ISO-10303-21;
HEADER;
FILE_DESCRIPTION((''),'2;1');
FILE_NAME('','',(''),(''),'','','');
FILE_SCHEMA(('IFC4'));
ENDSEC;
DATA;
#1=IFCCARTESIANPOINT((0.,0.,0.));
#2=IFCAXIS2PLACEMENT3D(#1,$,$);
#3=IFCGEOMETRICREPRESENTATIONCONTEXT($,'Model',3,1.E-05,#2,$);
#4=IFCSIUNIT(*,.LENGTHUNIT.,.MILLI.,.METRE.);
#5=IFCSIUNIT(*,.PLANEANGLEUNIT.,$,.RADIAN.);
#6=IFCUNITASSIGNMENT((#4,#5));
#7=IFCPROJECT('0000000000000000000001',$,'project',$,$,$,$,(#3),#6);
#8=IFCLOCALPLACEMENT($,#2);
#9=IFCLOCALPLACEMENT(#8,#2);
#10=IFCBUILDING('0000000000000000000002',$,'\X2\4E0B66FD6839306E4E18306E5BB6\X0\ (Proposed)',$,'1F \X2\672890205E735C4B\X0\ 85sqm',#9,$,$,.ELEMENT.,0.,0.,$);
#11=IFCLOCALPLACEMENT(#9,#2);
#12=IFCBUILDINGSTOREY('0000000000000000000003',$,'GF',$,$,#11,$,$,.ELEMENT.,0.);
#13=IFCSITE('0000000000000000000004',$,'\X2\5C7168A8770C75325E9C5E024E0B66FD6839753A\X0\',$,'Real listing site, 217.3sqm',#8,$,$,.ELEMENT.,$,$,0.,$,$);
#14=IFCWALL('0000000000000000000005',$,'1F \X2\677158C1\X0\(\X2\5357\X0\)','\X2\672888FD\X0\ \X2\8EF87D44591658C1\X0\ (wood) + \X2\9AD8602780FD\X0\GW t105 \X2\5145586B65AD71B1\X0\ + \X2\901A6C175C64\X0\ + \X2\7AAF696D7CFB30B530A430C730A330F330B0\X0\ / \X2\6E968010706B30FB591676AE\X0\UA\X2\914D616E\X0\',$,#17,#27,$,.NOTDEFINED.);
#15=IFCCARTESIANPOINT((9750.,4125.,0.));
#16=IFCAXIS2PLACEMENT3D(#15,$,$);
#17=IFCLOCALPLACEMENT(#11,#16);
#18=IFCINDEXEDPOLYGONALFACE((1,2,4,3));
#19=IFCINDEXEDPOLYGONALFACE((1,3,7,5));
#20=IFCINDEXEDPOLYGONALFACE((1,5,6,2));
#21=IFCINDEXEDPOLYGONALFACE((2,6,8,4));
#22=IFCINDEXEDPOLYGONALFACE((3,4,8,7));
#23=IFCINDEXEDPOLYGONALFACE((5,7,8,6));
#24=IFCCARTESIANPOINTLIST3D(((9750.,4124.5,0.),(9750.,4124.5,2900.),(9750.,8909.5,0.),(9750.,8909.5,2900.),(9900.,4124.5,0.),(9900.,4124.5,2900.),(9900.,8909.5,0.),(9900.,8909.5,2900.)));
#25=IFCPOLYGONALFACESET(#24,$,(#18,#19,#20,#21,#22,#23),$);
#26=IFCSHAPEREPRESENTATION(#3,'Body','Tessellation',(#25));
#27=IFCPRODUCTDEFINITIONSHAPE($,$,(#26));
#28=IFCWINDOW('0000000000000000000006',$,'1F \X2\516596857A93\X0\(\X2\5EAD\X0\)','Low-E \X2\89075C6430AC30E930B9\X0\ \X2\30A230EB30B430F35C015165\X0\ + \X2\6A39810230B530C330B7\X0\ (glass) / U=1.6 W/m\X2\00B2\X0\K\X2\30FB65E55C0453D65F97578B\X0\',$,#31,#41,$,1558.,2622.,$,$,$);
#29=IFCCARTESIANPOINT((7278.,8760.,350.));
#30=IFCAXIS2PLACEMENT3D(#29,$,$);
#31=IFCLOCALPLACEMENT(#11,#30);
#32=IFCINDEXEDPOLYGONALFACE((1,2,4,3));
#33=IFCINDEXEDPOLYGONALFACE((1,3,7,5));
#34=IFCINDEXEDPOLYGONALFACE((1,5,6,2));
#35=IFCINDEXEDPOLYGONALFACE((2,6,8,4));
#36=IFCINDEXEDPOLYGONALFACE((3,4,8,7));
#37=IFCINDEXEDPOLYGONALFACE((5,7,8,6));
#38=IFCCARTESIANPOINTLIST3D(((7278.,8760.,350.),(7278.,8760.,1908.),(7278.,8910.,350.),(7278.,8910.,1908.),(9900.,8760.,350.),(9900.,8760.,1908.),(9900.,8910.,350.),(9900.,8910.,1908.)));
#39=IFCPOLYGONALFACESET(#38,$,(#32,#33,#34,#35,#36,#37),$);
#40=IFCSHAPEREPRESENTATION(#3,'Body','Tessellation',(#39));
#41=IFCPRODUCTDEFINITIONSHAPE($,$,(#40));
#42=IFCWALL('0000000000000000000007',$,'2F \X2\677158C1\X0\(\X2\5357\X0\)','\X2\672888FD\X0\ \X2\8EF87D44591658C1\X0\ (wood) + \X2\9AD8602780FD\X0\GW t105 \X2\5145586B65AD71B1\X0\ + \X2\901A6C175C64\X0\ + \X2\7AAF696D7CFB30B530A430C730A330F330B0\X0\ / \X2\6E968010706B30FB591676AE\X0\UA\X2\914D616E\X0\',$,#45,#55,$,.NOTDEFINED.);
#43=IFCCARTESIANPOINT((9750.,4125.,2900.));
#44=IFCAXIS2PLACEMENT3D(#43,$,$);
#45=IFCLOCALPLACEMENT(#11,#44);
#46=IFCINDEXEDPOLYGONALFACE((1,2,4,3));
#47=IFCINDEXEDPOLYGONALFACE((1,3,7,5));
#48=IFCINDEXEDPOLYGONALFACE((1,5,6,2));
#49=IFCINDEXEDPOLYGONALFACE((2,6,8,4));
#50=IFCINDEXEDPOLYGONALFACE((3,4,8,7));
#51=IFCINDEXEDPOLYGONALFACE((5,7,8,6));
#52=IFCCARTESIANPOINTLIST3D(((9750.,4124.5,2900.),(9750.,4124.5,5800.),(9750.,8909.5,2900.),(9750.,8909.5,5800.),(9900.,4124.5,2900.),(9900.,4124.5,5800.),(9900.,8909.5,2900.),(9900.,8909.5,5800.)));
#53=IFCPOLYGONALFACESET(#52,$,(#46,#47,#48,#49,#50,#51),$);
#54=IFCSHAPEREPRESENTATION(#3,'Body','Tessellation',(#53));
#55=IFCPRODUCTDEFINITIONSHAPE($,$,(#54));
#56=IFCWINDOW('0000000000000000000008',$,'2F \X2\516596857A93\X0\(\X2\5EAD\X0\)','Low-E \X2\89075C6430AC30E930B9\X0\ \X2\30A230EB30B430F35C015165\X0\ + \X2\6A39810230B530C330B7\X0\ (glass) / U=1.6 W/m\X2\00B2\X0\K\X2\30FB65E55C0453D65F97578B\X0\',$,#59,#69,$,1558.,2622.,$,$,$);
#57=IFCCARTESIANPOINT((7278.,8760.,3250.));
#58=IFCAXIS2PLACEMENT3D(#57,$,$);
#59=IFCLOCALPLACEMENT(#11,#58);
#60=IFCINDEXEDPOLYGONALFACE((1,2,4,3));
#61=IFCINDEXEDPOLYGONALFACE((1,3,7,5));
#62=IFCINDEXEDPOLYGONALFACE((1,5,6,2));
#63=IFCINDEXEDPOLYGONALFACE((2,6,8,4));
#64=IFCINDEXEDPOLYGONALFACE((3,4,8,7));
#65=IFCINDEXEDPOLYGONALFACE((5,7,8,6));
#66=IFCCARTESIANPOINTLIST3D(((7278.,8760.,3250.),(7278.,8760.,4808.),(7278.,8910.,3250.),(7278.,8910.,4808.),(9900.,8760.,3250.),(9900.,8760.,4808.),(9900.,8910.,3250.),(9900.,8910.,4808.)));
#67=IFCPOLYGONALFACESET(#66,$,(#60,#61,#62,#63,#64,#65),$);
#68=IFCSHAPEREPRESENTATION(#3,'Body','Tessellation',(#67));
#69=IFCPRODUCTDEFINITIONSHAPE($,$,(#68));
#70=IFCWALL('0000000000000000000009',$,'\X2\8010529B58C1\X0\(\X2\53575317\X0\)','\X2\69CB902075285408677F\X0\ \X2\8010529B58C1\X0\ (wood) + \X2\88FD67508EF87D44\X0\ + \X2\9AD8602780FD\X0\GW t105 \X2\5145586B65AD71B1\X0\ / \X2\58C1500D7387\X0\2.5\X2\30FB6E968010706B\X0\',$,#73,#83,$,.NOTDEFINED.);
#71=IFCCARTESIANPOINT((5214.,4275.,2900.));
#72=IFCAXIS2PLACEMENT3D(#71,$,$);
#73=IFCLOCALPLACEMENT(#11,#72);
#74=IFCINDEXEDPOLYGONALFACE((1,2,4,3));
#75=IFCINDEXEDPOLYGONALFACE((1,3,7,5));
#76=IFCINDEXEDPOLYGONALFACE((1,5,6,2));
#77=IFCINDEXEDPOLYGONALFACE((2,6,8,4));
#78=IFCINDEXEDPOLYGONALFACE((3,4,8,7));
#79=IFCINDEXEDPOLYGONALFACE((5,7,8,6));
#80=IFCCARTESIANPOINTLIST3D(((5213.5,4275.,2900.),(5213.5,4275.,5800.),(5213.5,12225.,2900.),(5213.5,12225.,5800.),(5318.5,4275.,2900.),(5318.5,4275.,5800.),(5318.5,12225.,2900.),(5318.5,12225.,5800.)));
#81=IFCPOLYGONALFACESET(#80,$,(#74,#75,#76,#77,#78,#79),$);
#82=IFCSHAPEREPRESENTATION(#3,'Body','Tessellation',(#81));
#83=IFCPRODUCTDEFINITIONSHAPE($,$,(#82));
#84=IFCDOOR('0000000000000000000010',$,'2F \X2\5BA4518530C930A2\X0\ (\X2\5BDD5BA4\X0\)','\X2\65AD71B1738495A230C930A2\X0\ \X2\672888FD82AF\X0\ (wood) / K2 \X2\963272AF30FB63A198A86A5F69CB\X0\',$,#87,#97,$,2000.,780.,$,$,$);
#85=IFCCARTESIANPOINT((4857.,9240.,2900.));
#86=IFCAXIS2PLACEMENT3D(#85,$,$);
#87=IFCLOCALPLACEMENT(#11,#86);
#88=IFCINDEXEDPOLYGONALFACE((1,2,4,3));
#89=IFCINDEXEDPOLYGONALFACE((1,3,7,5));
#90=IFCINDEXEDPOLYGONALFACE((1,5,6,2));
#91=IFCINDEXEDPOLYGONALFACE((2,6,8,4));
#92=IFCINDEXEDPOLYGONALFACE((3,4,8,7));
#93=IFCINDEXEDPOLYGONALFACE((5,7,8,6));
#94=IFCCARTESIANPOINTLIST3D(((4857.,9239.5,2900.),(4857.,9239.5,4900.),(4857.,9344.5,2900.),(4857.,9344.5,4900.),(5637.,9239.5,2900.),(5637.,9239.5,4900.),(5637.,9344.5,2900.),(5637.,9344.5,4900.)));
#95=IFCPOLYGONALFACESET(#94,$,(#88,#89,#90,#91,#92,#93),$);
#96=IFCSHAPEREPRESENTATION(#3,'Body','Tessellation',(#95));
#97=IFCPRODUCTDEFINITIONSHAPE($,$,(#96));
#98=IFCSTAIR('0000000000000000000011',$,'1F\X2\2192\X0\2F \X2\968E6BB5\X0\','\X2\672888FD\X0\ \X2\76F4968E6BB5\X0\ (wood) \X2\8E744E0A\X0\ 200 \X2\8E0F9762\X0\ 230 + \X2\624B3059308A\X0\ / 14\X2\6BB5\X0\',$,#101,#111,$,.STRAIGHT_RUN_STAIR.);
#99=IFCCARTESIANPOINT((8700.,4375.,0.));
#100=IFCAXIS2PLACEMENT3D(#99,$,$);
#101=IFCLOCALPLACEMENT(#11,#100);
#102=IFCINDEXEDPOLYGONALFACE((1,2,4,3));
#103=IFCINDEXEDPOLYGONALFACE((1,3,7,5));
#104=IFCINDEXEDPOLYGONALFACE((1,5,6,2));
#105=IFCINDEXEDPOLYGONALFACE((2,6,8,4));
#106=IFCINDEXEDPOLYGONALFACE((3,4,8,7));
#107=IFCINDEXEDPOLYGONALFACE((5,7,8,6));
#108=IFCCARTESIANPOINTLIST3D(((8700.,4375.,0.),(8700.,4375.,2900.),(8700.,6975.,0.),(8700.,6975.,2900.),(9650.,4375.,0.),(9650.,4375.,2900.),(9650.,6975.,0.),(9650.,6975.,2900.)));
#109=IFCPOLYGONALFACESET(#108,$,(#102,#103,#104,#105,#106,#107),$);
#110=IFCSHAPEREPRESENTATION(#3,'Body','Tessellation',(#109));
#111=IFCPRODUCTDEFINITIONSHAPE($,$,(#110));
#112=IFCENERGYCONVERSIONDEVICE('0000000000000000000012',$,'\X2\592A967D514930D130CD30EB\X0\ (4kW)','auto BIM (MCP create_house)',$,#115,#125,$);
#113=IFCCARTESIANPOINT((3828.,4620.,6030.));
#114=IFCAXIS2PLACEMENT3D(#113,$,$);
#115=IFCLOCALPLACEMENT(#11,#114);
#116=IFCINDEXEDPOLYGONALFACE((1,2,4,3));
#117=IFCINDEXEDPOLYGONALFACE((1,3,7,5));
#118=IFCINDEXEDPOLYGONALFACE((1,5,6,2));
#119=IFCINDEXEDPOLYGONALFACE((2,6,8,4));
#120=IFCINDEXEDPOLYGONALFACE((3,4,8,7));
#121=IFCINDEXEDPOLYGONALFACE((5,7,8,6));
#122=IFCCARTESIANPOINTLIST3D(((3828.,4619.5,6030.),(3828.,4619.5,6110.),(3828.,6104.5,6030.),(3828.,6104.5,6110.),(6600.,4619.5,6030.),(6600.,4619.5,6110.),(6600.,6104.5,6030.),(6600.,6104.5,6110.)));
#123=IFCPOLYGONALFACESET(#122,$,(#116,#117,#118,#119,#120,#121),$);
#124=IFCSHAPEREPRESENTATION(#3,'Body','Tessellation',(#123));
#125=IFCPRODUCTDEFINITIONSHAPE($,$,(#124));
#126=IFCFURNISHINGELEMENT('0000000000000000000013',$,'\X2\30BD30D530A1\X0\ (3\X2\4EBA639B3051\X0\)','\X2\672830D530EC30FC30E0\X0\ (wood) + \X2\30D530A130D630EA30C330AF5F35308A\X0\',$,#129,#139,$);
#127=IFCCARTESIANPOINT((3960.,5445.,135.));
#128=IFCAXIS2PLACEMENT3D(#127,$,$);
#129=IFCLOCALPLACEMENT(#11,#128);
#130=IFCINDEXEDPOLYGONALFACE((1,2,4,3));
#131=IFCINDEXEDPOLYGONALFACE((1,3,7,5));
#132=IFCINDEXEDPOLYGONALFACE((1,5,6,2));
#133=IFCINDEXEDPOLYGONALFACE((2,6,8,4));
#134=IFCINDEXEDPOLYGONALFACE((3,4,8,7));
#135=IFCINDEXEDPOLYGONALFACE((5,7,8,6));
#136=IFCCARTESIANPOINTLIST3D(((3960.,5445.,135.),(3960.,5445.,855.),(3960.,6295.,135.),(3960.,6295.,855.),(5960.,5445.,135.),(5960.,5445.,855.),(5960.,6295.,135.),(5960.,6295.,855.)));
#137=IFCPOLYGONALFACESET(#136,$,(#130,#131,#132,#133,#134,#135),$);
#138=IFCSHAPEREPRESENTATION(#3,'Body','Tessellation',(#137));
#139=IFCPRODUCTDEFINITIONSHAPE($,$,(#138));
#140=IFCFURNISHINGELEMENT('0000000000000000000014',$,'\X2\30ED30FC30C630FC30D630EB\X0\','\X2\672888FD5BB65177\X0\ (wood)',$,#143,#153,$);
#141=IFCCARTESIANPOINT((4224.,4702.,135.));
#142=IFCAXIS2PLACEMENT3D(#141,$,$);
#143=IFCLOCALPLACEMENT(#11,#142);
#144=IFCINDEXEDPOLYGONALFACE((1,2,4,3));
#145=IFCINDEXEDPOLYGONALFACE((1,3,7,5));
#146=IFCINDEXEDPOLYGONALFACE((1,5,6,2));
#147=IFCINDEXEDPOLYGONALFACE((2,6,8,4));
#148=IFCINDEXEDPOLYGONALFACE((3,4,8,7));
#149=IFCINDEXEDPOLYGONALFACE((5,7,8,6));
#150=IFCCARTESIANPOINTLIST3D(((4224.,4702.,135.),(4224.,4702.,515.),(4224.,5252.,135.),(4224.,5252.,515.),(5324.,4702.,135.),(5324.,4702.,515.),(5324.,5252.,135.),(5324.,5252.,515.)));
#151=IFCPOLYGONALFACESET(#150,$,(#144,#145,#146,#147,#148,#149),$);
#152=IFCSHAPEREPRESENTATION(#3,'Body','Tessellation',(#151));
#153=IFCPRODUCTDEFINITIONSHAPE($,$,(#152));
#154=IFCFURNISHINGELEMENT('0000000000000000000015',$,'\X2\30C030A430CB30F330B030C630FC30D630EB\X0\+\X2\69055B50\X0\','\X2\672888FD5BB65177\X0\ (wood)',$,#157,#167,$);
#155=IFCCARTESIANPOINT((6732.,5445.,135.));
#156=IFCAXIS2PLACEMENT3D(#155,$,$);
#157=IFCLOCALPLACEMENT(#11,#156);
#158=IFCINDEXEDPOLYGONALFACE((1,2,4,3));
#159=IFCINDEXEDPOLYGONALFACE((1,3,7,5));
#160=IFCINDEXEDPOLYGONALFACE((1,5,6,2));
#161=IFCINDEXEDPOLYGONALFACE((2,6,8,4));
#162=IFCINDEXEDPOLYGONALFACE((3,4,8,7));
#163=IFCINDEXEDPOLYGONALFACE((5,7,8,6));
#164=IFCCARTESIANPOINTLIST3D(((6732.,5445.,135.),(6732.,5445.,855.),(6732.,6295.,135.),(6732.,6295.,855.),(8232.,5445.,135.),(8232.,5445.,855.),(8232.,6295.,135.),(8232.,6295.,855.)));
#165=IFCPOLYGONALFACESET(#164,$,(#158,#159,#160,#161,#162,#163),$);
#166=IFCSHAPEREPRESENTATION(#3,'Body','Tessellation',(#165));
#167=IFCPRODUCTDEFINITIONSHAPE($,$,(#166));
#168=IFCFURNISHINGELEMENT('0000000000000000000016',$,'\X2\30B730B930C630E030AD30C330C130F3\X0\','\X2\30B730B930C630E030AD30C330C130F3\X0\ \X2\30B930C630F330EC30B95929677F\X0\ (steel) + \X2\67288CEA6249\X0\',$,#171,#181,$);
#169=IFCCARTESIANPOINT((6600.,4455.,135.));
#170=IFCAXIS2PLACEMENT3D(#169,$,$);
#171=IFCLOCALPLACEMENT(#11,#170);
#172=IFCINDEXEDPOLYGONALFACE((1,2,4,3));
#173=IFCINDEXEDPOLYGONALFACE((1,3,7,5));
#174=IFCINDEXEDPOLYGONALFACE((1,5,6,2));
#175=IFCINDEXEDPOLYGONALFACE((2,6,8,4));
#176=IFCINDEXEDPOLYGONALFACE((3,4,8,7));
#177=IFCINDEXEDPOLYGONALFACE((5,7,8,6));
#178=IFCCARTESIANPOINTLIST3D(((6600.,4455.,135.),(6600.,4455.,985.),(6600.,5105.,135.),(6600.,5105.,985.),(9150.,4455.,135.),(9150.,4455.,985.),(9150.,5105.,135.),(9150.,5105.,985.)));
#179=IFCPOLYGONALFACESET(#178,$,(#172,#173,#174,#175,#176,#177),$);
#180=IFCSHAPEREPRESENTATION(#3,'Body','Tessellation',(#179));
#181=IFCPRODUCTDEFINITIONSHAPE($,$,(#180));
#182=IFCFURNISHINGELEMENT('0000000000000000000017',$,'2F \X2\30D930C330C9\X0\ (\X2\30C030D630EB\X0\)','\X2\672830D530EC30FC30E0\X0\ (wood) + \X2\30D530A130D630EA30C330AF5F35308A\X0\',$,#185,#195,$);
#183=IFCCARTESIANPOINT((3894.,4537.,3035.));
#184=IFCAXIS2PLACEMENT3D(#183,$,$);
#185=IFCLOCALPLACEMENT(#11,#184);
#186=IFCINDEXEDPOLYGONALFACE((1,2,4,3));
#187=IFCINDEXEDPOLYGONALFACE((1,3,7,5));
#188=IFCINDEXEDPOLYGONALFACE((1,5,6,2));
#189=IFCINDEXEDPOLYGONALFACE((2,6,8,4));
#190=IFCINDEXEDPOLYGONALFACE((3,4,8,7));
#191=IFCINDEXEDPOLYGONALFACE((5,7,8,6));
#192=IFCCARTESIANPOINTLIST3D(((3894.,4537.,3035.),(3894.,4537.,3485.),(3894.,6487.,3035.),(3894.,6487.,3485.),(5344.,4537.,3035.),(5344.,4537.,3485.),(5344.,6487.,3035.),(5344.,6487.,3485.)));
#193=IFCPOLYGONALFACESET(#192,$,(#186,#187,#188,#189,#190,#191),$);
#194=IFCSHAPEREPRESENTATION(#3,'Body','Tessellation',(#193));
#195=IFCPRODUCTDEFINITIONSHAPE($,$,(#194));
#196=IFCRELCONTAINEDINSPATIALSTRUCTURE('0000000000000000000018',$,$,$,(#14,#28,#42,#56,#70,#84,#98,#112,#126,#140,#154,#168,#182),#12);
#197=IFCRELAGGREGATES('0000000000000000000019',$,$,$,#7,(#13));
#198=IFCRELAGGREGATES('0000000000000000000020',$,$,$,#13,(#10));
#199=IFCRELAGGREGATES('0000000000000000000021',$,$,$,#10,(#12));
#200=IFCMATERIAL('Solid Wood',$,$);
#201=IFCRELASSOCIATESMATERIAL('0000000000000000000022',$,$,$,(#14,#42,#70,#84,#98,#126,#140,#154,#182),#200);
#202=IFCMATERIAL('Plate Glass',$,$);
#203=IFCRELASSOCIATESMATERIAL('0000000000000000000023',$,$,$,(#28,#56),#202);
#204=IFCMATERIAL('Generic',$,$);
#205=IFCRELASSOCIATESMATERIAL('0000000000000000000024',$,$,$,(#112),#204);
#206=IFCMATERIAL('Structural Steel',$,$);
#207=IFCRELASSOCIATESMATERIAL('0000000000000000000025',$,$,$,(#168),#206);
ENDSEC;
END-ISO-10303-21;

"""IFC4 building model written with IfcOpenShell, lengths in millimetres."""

from ifc_helpers import new_model, si_unit, frame, frame_2d, origin, place, context, project, spatial, rectangle, extrude, material, element, fill, save


model = new_model("IFC4")

# Units and contexts
model_context = context("Model", 3, precision=1e-05, world=origin())
ifc_project = project(units=[si_unit("LENGTHUNIT", "METRE", prefix="MILLI"), si_unit("PLANEANGLEUNIT", "RADIAN")], contexts=[model_context])

# Site, building, storey
site_placement = place(None, origin())
site = spatial("IfcSite", under=ifc_project, at=site_placement, Name="山梨県甲府市下曽根町", ObjectType="Real listing site, 217.3sqm", CompositionType="ELEMENT", RefElevation=0.0)
building_placement = place(site_placement, origin())
building = spatial("IfcBuilding", under=site, at=building_placement, Name="下曽根の丘の家 (Proposed)", ObjectType="1F 木造平屋 85sqm", CompositionType="ELEMENT", ElevationOfRefHeight=0.0, ElevationOfTerrain=0.0)
storey_placement = place(building_placement, origin())
storey = spatial("IfcBuildingStorey", under=building, at=storey_placement, Name="GF", CompositionType="ELEMENT", Elevation=0.0)

# Wall, opening, window
ifc_material_1 = material(Name="Solid Wood")
wall_1_placement = place(storey_placement, frame((9750.0, 4125.0, 0.0)))
wall_1 = element("IfcWall", 1, at=wall_1_placement, inside=storey, material=ifc_material_1, Name="1F 東壁(南)", Description="木製 軸組外壁 (wood) + 高性能GW t105 充填断熱 + 通気層 + 窯業系サイディング / 準耐火・外皮UA配慮", PredefinedType="NOTDEFINED", context=model_context, shape_type="SweptSolid", body=[
    extrude(rectangle(XDim=150.0, YDim=4785.0, at=frame_2d((75.0, 2392.0))), frame((9750.0, 4125.0, 0.0)), (0.0, 0.0, 1.0), 2900.0),
])
opening_1_placement = place(storey_placement, frame((7278.0, 8760.0, 350.0)))
opening_1 = element("IfcOpeningElement", 2, at=opening_1_placement, cuts=wall_1, PredefinedType="NOTDEFINED", context=model_context, shape_type="SweptSolid", body=[
    extrude(rectangle(XDim=2622.0, YDim=150.0, at=frame_2d((1311.0, 75.0))), frame((7278.0, 8760.0, 350.0)), (0.0, 0.0, 1.0), 1558.0),
])
ifc_material_2 = material(Name="Plate Glass")
window_1_placement = place(storey_placement, frame((7278.0, 8760.0, 350.0)))
window_1 = element("IfcWindow", 3, at=window_1_placement, inside=storey, material=ifc_material_2, Name="1F 入隅窓(庭)", Description="Low-E 複層ガラス アルゴン封入 + 樹脂サッシ (glass) / U=1.6 W/m²K・日射取得型", OverallHeight=1558.0, OverallWidth=2622.0, context=model_context, shape_type="SweptSolid", body=[
    extrude(rectangle(XDim=2622.0, YDim=150.0, at=frame_2d((1311.0, 75.0))), frame((7278.0, 8760.0, 350.0)), (0.0, 0.0, 1.0), 1558.0),
])
fill(opening_1, window_1)

# Wall, opening, window
wall_2_placement = place(storey_placement, frame((9750.0, 4125.0, 2900.0)))
wall_2 = element("IfcWall", 4, at=wall_2_placement, inside=storey, material=ifc_material_1, Name="2F 東壁(南)", Description="木製 軸組外壁 (wood) + 高性能GW t105 充填断熱 + 通気層 + 窯業系サイディング / 準耐火・外皮UA配慮", PredefinedType="NOTDEFINED", context=model_context, shape_type="SweptSolid", body=[
    extrude(rectangle(XDim=150.0, YDim=4785.0, at=frame_2d((75.0, 2392.0))), frame((9750.0, 4125.0, 2900.0)), (0.0, 0.0, 1.0), 2900.0),
])
opening_2_placement = place(storey_placement, frame((7278.0, 8760.0, 3250.0)))
opening_2 = element("IfcOpeningElement", 5, at=opening_2_placement, cuts=wall_2, PredefinedType="NOTDEFINED", context=model_context, shape_type="SweptSolid", body=[
    extrude(rectangle(XDim=2622.0, YDim=150.0, at=frame_2d((1311.0, 75.0))), frame((7278.0, 8760.0, 3250.0)), (0.0, 0.0, 1.0), 1558.0),
])
window_2_placement = place(storey_placement, frame((7278.0, 8760.0, 3250.0)))
window_2 = element("IfcWindow", 6, at=window_2_placement, inside=storey, material=ifc_material_2, Name="2F 入隅窓(庭)", Description="Low-E 複層ガラス アルゴン封入 + 樹脂サッシ (glass) / U=1.6 W/m²K・日射取得型", OverallHeight=1558.0, OverallWidth=2622.0, context=model_context, shape_type="SweptSolid", body=[
    extrude(rectangle(XDim=2622.0, YDim=150.0, at=frame_2d((1311.0, 75.0))), frame((7278.0, 8760.0, 3250.0)), (0.0, 0.0, 1.0), 1558.0),
])
fill(opening_2, window_2)

# Wall, opening, door
wall_3_placement = place(storey_placement, frame((5214.0, 4275.0, 2900.0)))
wall_3 = element("IfcWall", 7, at=wall_3_placement, inside=storey, material=ifc_material_1, Name="耐力壁(南北)", Description="構造用合板 耐力壁 (wood) + 製材軸組 + 高性能GW t105 充填断熱 / 壁倍率2.5・準耐火", PredefinedType="NOTDEFINED", context=model_context, shape_type="SweptSolid", body=[
    extrude(rectangle(XDim=105.0, YDim=7950.0, at=frame_2d((52.0, 3975.0))), frame((5214.0, 4275.0, 2900.0)), (0.0, 0.0, 1.0), 2900.0),
])
opening_3_placement = place(storey_placement, frame((4857.0, 9240.0, 2900.0)))
opening_3 = element("IfcOpeningElement", 8, at=opening_3_placement, cuts=wall_3, PredefinedType="NOTDEFINED", context=model_context, shape_type="SweptSolid", body=[
    extrude(rectangle(XDim=780.0, YDim=105.0, at=frame_2d((390.0, 52.0))), frame((4857.0, 9240.0, 2900.0)), (0.0, 0.0, 1.0), 2000.0),
])
door_1_placement = place(storey_placement, frame((4857.0, 9240.0, 2900.0)))
door_1 = element("IfcDoor", 9, at=door_1_placement, inside=storey, material=ifc_material_1, Name="2F 室内ドア (寝室)", Description="断熱玄関ドア 木製芯 (wood) / K2 防犯・採風機構", OverallHeight=2000.0, OverallWidth=780.0, context=model_context, shape_type="SweptSolid", body=[
    extrude(rectangle(XDim=780.0, YDim=105.0, at=frame_2d((390.0, 52.0))), frame((4857.0, 9240.0, 2900.0)), (0.0, 0.0, 1.0), 2000.0),
])
fill(opening_3, door_1)

# Stair
stair_placement = place(storey_placement, frame((8700.0, 4375.0, 0.0)))
element("IfcStair", 10, at=stair_placement, inside=storey, material=ifc_material_1, Name="1F→2F 階段", Description="木製 直階段 (wood) 蹴上 200 踏面 230 + 手すり / 14段", PredefinedType="STRAIGHT_RUN_STAIR", context=model_context, shape_type="SweptSolid", body=[
    extrude(rectangle(XDim=950.0, YDim=2600.0, at=frame_2d((475.0, 1300.0))), frame((8700.0, 4375.0, 0.0)), (0.0, 0.0, 1.0), 2900.0),
])

# Energy conversion device
ifc_material_3 = material(Name="Generic")
energy_conversion_device_placement = place(storey_placement, frame((3828.0, 4620.0, 6030.0)))
element("IfcEnergyConversionDevice", 11, at=energy_conversion_device_placement, inside=storey, material=ifc_material_3, Name="太陽光パネル (4kW)", Description="auto BIM (MCP create_house)", context=model_context, shape_type="SweptSolid", body=[
    extrude(rectangle(XDim=2772.0, YDim=1485.0, at=frame_2d((1386.0, 742.0))), frame((3828.0, 4620.0, 6030.0)), (0.0, 0.0, 1.0), 80.0),
])

# Furnishing elements
furnishing_1_placement = place(storey_placement, frame((3960.0, 5445.0, 135.0)))
element("IfcFurnishingElement", 12, at=furnishing_1_placement, inside=storey, material=ifc_material_1, Name="ソファ (3人掛け)", Description="木フレーム (wood) + ファブリック張り", context=model_context, shape_type="SweptSolid", body=[
    extrude(rectangle(XDim=2000.0, YDim=850.0, at=frame_2d((1000.0, 425.0))), frame((3960.0, 5445.0, 135.0)), (0.0, 0.0, 1.0), 720.0),
])
furnishing_2_placement = place(storey_placement, frame((4224.0, 4702.0, 135.0)))
element("IfcFurnishingElement", 13, at=furnishing_2_placement, inside=storey, material=ifc_material_1, Name="ローテーブル", Description="木製家具 (wood)", context=model_context, shape_type="SweptSolid", body=[
    extrude(rectangle(XDim=1100.0, YDim=550.0, at=frame_2d((550.0, 275.0))), frame((4224.0, 4702.0, 135.0)), (0.0, 0.0, 1.0), 380.0),
])
furnishing_3_placement = place(storey_placement, frame((6732.0, 5445.0, 135.0)))
element("IfcFurnishingElement", 14, at=furnishing_3_placement, inside=storey, material=ifc_material_1, Name="ダイニングテーブル+椅子", Description="木製家具 (wood)", context=model_context, shape_type="SweptSolid", body=[
    extrude(rectangle(XDim=1500.0, YDim=850.0, at=frame_2d((750.0, 425.0))), frame((6732.0, 5445.0, 135.0)), (0.0, 0.0, 1.0), 720.0),
])
ifc_material_4 = material(Name="Structural Steel")
furnishing_4_placement = place(storey_placement, frame((6600.0, 4455.0, 135.0)))
element("IfcFurnishingElement", 15, at=furnishing_4_placement, inside=storey, material=ifc_material_4, Name="システムキッチン", Description="システムキッチン ステンレス天板 (steel) + 木質扉", context=model_context, shape_type="SweptSolid", body=[
    extrude(rectangle(XDim=2550.0, YDim=650.0, at=frame_2d((1275.0, 325.0))), frame((6600.0, 4455.0, 135.0)), (0.0, 0.0, 1.0), 850.0),
])
furnishing_5_placement = place(storey_placement, frame((3894.0, 4537.0, 3035.0)))
element("IfcFurnishingElement", 16, at=furnishing_5_placement, inside=storey, material=ifc_material_1, Name="2F ベッド (ダブル)", Description="木フレーム (wood) + ファブリック張り", context=model_context, shape_type="SweptSolid", body=[
    extrude(rectangle(XDim=1450.0, YDim=1950.0, at=frame_2d((725.0, 975.0))), frame((3894.0, 4537.0, 3035.0)), (0.0, 0.0, 1.0), 450.0),
])

save(model, "model.ifc")
